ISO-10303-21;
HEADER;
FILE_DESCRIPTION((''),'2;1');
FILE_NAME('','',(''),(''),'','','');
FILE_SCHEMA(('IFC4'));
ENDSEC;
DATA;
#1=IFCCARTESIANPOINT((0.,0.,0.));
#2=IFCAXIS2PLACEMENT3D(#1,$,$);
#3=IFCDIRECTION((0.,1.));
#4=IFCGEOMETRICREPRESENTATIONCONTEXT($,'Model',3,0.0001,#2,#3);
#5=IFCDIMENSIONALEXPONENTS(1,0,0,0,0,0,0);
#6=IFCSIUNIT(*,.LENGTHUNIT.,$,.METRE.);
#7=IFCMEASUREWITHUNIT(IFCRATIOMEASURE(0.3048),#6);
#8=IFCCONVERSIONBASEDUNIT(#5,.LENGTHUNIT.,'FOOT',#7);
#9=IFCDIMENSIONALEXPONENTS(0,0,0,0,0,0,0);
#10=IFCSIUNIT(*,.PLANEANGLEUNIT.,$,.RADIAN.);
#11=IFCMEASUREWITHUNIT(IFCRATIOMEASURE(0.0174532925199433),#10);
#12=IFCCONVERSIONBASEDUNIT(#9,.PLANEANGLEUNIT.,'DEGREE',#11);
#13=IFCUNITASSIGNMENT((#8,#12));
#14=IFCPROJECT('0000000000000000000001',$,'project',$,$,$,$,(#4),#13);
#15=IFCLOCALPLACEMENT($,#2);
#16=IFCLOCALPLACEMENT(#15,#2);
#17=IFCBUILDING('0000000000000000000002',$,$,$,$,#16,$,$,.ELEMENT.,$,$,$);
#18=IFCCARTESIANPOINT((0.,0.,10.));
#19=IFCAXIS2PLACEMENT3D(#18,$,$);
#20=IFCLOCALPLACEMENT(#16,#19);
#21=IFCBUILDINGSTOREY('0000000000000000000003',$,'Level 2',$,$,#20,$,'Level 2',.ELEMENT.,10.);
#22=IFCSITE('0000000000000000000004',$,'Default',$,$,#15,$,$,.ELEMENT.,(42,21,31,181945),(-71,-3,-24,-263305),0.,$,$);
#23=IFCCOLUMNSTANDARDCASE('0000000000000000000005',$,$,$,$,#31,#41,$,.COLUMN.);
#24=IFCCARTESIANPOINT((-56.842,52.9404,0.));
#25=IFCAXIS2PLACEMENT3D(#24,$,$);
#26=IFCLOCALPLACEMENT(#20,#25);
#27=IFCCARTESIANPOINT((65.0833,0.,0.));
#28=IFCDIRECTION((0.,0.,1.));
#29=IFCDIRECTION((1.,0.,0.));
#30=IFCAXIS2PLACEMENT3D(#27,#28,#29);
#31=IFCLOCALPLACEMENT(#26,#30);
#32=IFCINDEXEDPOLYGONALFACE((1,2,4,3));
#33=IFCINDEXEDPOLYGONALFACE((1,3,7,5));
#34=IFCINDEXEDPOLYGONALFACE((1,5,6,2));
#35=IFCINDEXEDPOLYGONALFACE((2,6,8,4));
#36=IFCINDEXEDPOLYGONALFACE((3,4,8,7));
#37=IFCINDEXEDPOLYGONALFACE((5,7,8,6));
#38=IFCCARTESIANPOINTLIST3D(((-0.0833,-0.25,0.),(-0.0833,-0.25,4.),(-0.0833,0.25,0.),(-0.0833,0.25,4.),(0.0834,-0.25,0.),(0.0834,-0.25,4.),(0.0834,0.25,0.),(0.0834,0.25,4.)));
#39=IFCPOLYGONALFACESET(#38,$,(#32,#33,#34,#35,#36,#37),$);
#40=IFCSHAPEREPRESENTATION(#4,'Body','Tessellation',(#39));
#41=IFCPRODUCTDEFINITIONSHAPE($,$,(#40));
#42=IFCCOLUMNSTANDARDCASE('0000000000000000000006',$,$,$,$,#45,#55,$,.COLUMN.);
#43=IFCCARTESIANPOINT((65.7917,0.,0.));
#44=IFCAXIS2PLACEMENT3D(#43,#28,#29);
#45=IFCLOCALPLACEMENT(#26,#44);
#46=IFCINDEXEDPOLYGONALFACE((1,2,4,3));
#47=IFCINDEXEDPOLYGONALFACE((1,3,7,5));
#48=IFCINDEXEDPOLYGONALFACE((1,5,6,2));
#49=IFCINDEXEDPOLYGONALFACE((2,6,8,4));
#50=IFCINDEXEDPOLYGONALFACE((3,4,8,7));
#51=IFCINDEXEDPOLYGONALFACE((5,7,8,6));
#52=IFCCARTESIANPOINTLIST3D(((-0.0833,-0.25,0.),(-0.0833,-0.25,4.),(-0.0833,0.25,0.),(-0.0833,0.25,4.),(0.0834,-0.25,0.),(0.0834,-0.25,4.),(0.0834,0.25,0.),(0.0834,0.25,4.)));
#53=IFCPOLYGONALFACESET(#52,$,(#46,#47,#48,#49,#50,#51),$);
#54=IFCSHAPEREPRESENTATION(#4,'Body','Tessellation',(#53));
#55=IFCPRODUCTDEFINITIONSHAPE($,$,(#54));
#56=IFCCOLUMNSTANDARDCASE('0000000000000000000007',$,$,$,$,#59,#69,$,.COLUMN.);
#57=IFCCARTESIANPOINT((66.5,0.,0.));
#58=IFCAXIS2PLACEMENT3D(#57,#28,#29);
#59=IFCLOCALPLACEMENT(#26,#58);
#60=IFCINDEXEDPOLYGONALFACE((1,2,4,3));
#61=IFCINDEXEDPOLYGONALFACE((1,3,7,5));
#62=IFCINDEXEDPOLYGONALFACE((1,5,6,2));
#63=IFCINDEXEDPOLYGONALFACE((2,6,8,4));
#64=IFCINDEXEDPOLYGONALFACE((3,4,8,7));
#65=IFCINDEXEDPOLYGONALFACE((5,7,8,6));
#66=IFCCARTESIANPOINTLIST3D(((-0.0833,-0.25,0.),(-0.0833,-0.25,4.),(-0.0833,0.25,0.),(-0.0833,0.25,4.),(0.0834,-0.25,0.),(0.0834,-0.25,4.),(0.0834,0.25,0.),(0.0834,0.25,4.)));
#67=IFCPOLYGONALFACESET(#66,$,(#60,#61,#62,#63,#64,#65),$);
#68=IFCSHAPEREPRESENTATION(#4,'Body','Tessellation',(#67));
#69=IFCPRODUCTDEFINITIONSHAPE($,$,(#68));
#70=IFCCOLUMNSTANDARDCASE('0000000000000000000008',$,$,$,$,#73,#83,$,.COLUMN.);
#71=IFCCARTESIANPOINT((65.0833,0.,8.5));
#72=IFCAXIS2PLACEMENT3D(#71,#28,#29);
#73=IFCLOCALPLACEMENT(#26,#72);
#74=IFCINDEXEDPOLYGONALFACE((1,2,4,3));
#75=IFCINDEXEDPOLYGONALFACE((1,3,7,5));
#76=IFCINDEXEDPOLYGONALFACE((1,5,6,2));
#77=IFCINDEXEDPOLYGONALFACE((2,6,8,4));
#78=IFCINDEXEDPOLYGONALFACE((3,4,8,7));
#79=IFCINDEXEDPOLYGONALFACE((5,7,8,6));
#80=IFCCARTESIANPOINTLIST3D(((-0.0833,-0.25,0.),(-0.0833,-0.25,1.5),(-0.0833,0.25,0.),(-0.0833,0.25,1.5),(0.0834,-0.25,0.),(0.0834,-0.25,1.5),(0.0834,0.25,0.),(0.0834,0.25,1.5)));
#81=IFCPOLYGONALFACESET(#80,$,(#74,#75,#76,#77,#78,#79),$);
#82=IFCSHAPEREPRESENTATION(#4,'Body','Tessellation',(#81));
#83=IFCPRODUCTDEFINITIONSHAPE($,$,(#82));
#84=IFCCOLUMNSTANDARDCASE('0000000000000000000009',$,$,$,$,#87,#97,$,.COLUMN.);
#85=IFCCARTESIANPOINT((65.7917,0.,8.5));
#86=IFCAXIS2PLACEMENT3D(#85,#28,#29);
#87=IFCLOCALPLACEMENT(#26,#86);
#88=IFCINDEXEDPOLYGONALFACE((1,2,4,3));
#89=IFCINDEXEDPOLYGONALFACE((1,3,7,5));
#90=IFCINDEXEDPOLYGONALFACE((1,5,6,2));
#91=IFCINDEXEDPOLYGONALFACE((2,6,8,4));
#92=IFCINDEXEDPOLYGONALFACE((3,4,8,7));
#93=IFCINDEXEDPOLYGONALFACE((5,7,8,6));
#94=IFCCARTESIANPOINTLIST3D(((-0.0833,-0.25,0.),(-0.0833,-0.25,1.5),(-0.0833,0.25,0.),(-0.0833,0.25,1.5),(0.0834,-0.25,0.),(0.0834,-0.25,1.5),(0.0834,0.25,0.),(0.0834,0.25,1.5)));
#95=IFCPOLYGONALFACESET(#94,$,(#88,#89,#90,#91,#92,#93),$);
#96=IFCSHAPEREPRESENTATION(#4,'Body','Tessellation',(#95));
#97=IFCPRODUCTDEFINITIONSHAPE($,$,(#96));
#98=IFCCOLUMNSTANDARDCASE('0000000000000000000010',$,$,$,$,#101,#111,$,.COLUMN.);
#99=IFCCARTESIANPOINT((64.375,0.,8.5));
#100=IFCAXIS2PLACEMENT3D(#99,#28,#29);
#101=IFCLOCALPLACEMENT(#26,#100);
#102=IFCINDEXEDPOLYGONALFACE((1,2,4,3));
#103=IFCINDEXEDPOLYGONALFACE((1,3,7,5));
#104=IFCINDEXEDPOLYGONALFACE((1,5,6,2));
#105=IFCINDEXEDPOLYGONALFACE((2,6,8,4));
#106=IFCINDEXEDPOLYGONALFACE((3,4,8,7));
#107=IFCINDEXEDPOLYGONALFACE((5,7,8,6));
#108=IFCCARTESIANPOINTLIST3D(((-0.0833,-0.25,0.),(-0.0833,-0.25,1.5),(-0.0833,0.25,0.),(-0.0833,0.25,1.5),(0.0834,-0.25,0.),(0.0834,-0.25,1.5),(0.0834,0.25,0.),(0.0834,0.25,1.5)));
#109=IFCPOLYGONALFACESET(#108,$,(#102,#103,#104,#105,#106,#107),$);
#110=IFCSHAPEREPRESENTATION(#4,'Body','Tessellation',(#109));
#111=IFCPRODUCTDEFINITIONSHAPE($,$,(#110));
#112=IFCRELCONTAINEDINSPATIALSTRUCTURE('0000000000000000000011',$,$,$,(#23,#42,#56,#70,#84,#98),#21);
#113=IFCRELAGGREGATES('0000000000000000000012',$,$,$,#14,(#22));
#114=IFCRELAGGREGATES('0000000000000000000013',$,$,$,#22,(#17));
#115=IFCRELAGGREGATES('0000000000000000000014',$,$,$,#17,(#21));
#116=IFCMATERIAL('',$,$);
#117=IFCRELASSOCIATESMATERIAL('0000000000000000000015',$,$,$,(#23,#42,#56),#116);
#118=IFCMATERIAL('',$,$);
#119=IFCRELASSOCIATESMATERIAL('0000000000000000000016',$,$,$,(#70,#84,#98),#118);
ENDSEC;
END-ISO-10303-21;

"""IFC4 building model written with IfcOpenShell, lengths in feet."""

from ifc_helpers import new_model, entity, si_unit, converted_unit, direction, frame, origin, place, context, project, spatial, rectangle, extrude, material, element, save


model = new_model("IFC4")

# Units and contexts
model_context = context("Model", 3, precision=0.0001, world=origin(), true_north=direction((0.0, 1.0)))
ifc_project = project(units=[converted_unit("LENGTHUNIT", "FOOT", entity("IfcRatioMeasure", 0.3048), si_unit("LENGTHUNIT", "METRE"), dimensions=[1, 0, 0, 0, 0, 0, 0]), converted_unit("PLANEANGLEUNIT", "DEGREE", entity("IfcRatioMeasure", 0.0174532925199433), si_unit("PLANEANGLEUNIT", "RADIAN"), dimensions=[0, 0, 0, 0, 0, 0, 0])], contexts=[model_context])

# Site, building, storey
site_placement = place(None, origin())
site = spatial("IfcSite", under=ifc_project, at=site_placement, Name="Default", CompositionType="ELEMENT", RefLatitude=(42, 21, 31, 181945), RefLongitude=(-71, -3, -24, -263305), RefElevation=0.0)
building_placement = place(site_placement, origin())
building = spatial("IfcBuilding", under=site, at=building_placement, CompositionType="ELEMENT")
storey_placement = place(building_placement, frame((0.0, 0.0, 10.0)))
storey = spatial("IfcBuildingStorey", under=building, at=storey_placement, Name="Level 2", LongName="Level 2", CompositionType="ELEMENT", Elevation=10.0)

# Columns
ifc_material_1 = material(Name="")
placement = place(storey_placement, frame((-56.842, 52.9404, 0.0)))
for number, where, z_axis, x_axis in (
    (1, (65.0833, 0.0, 0.0), (0.0, 0.0, 1.0), (1.0, 0.0, 0.0)),
    (2, (65.7917, 0.0, 0.0), (0.0, 0.0, 1.0), (1.0, 0.0, 0.0)),
    (3, (66.5, 0.0, 0.0), (0.0, 0.0, 1.0), (1.0, 0.0, 0.0)),
):
    element("IfcColumnStandardCase", number, at=place(placement, frame(where, z_axis=z_axis, x_axis=x_axis)), inside=storey, material=ifc_material_1, PredefinedType="COLUMN", context=model_context, shape_type="SweptSolid", body=[
        extrude(rectangle(XDim=0.1667, YDim=0.5), origin(), (0.0, 0.0, 1.0), 4.0),
    ])
ifc_material_2 = material(Name="")
for number, where, z_axis, x_axis in (
    (4, (65.0833, 0.0, 8.5), (0.0, 0.0, 1.0), (1.0, 0.0, 0.0)),
    (5, (65.7917, 0.0, 8.5), (0.0, 0.0, 1.0), (1.0, 0.0, 0.0)),
    (6, (64.375, 0.0, 8.5), (0.0, 0.0, 1.0), (1.0, 0.0, 0.0)),
):
    element("IfcColumnStandardCase", number, at=place(placement, frame(where, z_axis=z_axis, x_axis=x_axis)), inside=storey, material=ifc_material_2, PredefinedType="COLUMN", context=model_context, shape_type="SweptSolid", body=[
        extrude(rectangle(XDim=0.1667, YDim=0.5), origin(), (0.0, 0.0, 1.0), 1.5),
    ])

save(model, "model.ifc")
